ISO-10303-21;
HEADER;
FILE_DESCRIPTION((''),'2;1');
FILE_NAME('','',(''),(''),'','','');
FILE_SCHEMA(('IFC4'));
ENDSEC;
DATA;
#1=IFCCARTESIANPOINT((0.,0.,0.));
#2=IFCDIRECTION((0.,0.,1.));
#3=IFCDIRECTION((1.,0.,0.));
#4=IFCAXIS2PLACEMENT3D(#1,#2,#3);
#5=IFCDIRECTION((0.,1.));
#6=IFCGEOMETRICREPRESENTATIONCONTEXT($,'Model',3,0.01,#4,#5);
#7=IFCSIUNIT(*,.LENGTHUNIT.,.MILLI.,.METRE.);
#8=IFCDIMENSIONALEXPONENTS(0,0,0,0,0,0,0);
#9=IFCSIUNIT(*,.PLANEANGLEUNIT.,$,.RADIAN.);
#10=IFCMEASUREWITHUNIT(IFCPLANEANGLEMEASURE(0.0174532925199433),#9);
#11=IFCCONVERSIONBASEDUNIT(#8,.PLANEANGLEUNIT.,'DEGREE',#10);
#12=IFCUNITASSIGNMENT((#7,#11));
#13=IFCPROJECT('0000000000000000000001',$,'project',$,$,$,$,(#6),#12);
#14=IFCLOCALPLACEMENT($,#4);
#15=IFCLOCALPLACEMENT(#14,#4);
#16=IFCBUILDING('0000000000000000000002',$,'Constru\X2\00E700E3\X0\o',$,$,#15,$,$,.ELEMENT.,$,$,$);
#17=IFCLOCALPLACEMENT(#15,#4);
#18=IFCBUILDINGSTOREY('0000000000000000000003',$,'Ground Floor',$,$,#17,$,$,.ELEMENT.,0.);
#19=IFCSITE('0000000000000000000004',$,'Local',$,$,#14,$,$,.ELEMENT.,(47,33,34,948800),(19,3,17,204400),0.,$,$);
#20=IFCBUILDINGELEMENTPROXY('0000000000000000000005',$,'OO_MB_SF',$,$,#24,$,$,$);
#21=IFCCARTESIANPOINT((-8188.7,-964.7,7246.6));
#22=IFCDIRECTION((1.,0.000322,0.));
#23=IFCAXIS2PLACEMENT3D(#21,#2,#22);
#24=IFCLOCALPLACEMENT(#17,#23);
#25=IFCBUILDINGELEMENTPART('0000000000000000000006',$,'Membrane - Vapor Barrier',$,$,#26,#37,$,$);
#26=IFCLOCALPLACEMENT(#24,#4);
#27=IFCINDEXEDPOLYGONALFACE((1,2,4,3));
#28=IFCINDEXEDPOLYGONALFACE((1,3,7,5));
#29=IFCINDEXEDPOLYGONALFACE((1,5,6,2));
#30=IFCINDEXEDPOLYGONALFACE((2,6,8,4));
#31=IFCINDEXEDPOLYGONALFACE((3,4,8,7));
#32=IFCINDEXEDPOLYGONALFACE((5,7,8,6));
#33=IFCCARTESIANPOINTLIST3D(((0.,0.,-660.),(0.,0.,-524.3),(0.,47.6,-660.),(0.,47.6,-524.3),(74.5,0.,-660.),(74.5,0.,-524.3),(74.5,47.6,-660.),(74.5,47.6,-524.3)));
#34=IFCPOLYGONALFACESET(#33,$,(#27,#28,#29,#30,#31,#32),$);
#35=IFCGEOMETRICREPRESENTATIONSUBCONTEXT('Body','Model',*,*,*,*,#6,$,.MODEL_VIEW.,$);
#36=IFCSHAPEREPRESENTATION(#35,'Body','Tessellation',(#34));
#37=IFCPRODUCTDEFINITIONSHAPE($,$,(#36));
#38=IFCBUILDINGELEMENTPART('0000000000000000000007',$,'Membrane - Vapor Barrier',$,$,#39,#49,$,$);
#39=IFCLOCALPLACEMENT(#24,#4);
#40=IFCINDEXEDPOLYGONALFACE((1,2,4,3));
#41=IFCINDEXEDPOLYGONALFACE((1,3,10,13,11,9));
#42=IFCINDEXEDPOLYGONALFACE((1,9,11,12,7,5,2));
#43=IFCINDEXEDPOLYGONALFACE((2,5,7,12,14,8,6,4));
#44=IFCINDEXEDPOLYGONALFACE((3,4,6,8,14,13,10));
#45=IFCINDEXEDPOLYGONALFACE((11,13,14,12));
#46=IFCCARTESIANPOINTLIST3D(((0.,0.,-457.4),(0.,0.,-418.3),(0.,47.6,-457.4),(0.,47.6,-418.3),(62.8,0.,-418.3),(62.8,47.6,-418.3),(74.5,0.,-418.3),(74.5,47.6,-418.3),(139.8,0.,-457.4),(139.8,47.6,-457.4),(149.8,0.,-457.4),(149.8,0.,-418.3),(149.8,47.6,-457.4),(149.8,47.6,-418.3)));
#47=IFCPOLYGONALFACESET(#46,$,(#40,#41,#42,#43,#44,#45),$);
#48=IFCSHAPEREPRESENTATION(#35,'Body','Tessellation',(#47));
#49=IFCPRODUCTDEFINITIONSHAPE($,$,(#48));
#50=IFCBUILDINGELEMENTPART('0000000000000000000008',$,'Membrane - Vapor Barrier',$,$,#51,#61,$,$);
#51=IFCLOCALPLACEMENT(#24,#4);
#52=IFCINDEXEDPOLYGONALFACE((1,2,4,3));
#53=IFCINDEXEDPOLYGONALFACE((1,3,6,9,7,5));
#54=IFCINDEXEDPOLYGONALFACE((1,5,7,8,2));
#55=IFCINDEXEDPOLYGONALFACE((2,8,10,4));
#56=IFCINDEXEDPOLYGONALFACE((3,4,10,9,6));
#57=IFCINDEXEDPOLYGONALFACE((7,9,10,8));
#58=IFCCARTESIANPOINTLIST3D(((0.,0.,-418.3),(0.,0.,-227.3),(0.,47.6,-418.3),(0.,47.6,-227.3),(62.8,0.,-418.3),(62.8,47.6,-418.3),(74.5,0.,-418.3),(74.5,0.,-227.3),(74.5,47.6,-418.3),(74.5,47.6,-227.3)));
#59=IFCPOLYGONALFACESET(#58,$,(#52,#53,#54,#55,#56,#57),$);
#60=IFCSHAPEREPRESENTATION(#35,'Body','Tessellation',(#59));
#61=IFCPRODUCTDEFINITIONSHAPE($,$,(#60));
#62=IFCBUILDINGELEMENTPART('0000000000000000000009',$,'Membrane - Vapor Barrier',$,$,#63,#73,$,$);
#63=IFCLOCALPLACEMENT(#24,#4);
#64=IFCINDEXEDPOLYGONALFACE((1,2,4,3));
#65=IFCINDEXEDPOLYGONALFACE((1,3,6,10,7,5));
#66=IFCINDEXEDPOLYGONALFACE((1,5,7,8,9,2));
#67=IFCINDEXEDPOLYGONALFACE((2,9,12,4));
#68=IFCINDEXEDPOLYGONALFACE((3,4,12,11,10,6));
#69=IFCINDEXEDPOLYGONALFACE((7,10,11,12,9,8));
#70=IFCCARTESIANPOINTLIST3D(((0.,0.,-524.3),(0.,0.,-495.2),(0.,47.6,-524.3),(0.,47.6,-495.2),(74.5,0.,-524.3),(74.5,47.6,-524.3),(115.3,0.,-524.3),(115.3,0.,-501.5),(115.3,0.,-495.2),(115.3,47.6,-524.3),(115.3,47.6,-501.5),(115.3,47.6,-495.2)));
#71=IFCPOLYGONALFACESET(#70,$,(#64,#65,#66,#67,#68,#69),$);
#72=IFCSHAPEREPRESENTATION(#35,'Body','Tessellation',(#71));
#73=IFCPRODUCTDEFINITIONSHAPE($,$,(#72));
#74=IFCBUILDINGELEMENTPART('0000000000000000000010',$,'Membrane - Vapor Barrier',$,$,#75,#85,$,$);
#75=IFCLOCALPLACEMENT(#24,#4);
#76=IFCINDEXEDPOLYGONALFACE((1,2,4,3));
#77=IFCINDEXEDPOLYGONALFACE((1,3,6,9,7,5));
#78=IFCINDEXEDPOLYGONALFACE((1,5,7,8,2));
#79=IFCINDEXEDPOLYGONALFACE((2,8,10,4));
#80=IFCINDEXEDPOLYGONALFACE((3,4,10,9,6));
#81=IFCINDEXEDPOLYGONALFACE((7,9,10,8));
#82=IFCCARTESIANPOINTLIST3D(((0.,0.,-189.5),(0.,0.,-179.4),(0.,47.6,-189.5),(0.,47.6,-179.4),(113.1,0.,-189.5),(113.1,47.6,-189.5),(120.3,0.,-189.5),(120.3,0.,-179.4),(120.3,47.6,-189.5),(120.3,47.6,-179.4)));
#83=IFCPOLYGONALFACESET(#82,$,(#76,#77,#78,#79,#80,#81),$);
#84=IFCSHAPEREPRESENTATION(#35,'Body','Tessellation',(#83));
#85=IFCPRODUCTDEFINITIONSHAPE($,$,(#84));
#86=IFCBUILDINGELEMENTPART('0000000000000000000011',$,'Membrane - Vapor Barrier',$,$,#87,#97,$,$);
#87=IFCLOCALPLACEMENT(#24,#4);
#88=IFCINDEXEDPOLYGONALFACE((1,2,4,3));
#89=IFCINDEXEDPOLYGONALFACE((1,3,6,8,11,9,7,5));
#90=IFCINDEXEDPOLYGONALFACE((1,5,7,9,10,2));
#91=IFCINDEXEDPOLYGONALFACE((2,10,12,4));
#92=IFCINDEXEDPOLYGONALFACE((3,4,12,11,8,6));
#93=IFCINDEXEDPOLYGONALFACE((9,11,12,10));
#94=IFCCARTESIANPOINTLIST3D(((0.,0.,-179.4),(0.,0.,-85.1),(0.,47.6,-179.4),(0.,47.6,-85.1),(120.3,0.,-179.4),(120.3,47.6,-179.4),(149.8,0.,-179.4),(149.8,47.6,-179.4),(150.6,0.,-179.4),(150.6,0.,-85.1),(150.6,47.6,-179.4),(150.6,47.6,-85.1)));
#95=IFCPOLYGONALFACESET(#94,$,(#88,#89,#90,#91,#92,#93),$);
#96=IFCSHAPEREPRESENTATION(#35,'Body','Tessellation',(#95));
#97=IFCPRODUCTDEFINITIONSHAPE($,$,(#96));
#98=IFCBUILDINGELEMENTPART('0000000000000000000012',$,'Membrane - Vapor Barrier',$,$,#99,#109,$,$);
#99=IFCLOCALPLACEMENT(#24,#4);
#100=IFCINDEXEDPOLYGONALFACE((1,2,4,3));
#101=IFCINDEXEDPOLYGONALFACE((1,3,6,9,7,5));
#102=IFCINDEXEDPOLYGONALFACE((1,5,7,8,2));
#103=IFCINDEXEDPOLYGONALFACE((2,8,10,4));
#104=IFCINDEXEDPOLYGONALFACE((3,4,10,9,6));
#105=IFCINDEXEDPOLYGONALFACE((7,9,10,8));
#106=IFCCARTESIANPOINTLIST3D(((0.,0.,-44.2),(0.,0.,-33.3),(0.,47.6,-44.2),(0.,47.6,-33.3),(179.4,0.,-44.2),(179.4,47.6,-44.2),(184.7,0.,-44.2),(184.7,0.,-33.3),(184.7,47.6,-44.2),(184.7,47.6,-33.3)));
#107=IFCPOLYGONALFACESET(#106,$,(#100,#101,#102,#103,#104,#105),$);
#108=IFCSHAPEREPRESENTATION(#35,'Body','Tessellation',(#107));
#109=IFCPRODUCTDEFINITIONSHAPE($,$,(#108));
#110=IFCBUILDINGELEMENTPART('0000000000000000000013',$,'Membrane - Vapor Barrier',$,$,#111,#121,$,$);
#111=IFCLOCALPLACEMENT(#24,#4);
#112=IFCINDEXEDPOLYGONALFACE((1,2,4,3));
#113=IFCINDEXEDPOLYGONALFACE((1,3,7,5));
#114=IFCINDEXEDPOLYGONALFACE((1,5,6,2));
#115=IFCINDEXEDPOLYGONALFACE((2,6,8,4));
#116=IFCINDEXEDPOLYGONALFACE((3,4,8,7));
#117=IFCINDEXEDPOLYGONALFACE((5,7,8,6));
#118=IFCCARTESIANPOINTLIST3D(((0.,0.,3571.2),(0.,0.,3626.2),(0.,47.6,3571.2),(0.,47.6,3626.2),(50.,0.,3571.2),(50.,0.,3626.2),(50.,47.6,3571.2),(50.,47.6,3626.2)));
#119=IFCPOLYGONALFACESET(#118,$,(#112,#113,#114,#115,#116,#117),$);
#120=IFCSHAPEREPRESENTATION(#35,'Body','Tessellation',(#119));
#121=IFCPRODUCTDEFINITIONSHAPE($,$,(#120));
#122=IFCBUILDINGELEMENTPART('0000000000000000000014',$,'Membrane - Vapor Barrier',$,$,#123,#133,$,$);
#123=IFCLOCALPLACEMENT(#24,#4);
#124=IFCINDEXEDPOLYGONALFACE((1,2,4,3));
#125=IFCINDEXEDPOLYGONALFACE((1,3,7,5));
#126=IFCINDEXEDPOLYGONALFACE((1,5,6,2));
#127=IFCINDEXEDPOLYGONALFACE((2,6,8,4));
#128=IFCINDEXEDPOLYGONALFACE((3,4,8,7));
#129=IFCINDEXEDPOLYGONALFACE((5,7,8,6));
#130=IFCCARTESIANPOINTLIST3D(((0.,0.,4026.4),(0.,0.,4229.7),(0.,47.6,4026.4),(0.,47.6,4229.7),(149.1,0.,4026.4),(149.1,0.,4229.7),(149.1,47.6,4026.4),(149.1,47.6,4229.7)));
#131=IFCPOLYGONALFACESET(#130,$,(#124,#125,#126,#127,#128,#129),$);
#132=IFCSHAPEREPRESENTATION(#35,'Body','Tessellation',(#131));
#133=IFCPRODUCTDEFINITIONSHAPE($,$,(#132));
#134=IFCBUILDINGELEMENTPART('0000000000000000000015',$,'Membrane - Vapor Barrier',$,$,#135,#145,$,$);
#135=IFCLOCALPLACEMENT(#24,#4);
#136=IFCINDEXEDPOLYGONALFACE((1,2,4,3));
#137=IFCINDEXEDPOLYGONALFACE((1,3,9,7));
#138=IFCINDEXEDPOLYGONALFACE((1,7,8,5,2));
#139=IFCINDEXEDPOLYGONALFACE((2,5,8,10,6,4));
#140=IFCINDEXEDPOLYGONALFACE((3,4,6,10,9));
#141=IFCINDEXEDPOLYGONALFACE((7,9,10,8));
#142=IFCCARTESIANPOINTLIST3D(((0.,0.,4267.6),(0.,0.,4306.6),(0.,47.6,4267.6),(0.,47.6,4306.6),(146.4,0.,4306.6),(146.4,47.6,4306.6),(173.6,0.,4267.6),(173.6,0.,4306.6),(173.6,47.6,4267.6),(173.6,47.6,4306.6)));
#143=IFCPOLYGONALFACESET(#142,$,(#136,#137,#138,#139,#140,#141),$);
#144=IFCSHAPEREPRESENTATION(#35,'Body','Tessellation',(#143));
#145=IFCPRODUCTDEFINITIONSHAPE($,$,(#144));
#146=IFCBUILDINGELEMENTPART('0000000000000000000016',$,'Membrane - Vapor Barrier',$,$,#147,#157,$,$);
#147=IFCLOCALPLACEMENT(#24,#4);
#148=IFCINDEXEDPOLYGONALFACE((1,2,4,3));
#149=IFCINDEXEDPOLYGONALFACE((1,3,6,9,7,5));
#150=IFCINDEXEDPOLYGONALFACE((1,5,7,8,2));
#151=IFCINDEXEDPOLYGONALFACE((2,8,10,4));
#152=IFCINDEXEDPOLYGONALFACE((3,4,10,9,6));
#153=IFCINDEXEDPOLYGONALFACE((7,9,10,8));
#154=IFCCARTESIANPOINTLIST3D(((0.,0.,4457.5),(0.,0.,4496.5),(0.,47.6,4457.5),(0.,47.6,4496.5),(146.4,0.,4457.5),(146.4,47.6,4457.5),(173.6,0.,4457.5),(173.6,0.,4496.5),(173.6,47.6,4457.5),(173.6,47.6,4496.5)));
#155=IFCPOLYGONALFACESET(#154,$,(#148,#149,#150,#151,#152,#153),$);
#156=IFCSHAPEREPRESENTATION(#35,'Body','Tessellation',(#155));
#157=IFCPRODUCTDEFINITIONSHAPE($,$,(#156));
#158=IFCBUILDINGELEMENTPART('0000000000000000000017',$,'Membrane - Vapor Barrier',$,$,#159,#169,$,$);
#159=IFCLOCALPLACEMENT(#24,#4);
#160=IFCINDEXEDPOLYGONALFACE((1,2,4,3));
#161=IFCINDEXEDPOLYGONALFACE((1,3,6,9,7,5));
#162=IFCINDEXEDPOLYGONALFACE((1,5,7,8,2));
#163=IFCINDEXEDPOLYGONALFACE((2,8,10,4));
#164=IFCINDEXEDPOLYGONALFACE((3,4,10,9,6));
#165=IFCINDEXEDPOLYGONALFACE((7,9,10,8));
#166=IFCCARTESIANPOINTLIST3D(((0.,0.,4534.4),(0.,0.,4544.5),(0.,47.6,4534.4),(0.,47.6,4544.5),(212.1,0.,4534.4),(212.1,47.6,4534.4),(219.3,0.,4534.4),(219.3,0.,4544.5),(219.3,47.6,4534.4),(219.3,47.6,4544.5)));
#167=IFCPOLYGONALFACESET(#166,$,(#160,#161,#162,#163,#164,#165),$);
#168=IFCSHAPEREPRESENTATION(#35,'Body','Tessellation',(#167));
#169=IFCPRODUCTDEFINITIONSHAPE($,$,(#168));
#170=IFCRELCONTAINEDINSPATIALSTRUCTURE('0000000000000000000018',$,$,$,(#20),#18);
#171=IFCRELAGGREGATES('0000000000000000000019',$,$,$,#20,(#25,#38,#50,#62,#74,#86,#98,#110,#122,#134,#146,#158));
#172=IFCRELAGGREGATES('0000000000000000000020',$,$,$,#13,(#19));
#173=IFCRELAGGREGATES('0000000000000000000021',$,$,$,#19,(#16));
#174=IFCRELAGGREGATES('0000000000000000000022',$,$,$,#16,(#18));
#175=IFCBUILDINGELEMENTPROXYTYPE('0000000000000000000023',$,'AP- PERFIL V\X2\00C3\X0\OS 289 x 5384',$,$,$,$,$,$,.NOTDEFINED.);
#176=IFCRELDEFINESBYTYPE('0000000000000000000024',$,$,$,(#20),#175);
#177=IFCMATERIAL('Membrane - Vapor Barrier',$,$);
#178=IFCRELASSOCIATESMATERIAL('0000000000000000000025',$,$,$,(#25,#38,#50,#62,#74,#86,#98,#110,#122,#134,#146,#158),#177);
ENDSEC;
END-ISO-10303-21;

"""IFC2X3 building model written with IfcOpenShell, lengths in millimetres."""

from ifc_helpers import new_model, entity, si_unit, converted_unit, direction, frame, origin_with_axes, place, context, subcontext, project, spatial, polyline, outline, extrude, material, type_object, element, aggregate, save


model = new_model("IFC2X3")

# Units and contexts
model_context = context("Model", 3, precision=0.01, world=origin_with_axes(), true_north=direction((0.0, 1.0)))
body_context = subcontext(model_context, "Body", "Model", "MODEL_VIEW")
ifc_project = project(units=[si_unit("LENGTHUNIT", "METRE", prefix="MILLI"), converted_unit("PLANEANGLEUNIT", "DEGREE", entity("IfcPlaneAngleMeasure", 0.0174532925199433), si_unit("PLANEANGLEUNIT", "RADIAN"), dimensions=[0, 0, 0, 0, 0, 0, 0])], contexts=[model_context])

# Site, building, storey
site_placement = place(None, origin_with_axes())
site = spatial("IfcSite", under=ifc_project, at=site_placement, Name="Local", CompositionType="ELEMENT", RefLatitude=(47, 33, 34, 948800), RefLongitude=(19, 3, 17, 204400), RefElevation=0.0)
building_placement = place(site_placement, origin_with_axes())
building = spatial("IfcBuilding", under=site, at=building_placement, Name="Construção", CompositionType="ELEMENT")
storey_placement = place(building_placement, origin_with_axes())
storey = spatial("IfcBuildingStorey", under=building, at=storey_placement, Name="Ground Floor", CompositionType="ELEMENT", Elevation=0.0)

# Building element proxy, building element parts
building_element_proxy_type = type_object("IfcBuildingElementProxyType", Name="AP- PERFIL VÃOS 289 x 5384", PredefinedType="NOTDEFINED")
proxy_1_placement = place(storey_placement, frame((-8188.7, -964.7, 7246.6), z_axis=(0.0, 0.0, 1.0), x_axis=(1.0, 0.000322, 0.0)))
proxy_1 = element("IfcBuildingElementProxy", 1, at=proxy_1_placement, inside=storey, type_object=building_element_proxy_type, Name="OO_MB_SF")
ifc_material = material(Name="Membrane - Vapor Barrier")
building_element_part_1_placement = place(proxy_1_placement, origin_with_axes())
building_element_part_1 = element("IfcBuildingElementPart", 2, at=building_element_part_1_placement, material=ifc_material, Name="Membrane - Vapor Barrier", context=body_context, shape_type="SweptSolid", body=[
    extrude(outline(polyline([(0.0, -660.0), (74.5, -660.0), (74.5, -524.3), (0.0, -524.3), (0.0, -660.0)])), frame((0.0, 47.6, 0.0), z_axis=(0.0, -1.0, 0.0), x_axis=(1.0, 0.0, 0.0)), (0.0, 0.0, 1.0), 47.6),
])
building_element_part_2_placement = place(proxy_1_placement, origin_with_axes())
building_element_part_2 = element("IfcBuildingElementPart", 3, at=building_element_part_2_placement, material=ifc_material, Name="Membrane - Vapor Barrier", context=body_context, shape_type="SweptSolid", body=[
    extrude(outline(polyline([(62.8, -418.3), (0.0, -418.3), (0.0, -457.4), (139.8, -457.4), (149.8, -457.4), (149.8, -418.3), (74.5, -418.3), (62.8, -418.3)])), frame((0.0, 47.6, 0.0), z_axis=(0.0, -1.0, 0.0), x_axis=(1.0, 0.0, 0.0)), (0.0, 0.0, 1.0), 47.6),
])
building_element_part_3_placement = place(proxy_1_placement, origin_with_axes())
building_element_part_3 = element("IfcBuildingElementPart", 4, at=building_element_part_3_placement, material=ifc_material, Name="Membrane - Vapor Barrier", context=body_context, shape_type="SweptSolid", body=[
    extrude(outline(polyline([(0.0, -227.3), (0.0, -418.3), (62.8, -418.3), (74.5, -418.3), (74.5, -227.3), (0.0, -227.3)])), frame((0.0, 47.6, 0.0), z_axis=(0.0, -1.0, 0.0), x_axis=(1.0, 0.0, 0.0)), (0.0, 0.0, 1.0), 47.6),
])
building_element_part_4_placement = place(proxy_1_placement, origin_with_axes())
building_element_part_4 = element("IfcBuildingElementPart", 5, at=building_element_part_4_placement, material=ifc_material, Name="Membrane - Vapor Barrier", context=body_context, shape_type="SweptSolid", body=[
    extrude(outline(polyline([(0.0, -524.3), (74.5, -524.3), (115.3, -524.3), (115.3, -501.5), (115.3, -495.2), (0.0, -495.2), (0.0, -524.3)])), frame((0.0, 47.6, 0.0), z_axis=(0.0, -1.0, 0.0), x_axis=(1.0, 0.0, 0.0)), (0.0, 0.0, 1.0), 47.6),
])
building_element_part_5_placement = place(proxy_1_placement, origin_with_axes())
building_element_part_5 = element("IfcBuildingElementPart", 6, at=building_element_part_5_placement, material=ifc_material, Name="Membrane - Vapor Barrier", context=body_context, shape_type="SweptSolid", body=[
    extrude(outline(polyline([(120.3, -179.4), (0.0, -179.4), (0.0, -189.5), (113.1, -189.5), (120.3, -189.5), (120.3, -179.4)])), frame((0.0, 47.6, 0.0), z_axis=(0.0, -1.0, 0.0), x_axis=(1.0, 0.0, 0.0)), (0.0, 0.0, 1.0), 47.6),
])
building_element_part_6_placement = place(proxy_1_placement, origin_with_axes())
building_element_part_6 = element("IfcBuildingElementPart", 7, at=building_element_part_6_placement, material=ifc_material, Name="Membrane - Vapor Barrier", context=body_context, shape_type="SweptSolid", body=[
    extrude(outline(polyline([(0.0, -85.1), (0.0, -179.4), (120.3, -179.4), (149.8, -179.4), (150.6, -179.4), (150.6, -85.1), (0.0, -85.1)])), frame((0.0, 47.6, 0.0), z_axis=(0.0, -1.0, 0.0), x_axis=(1.0, 0.0, 0.0)), (0.0, 0.0, 1.0), 47.6),
])
building_element_part_7_placement = place(proxy_1_placement, origin_with_axes())
building_element_part_7 = element("IfcBuildingElementPart", 8, at=building_element_part_7_placement, material=ifc_material, Name="Membrane - Vapor Barrier", context=body_context, shape_type="SweptSolid", body=[
    extrude(outline(polyline([(184.7, -33.3), (0.0, -33.3), (0.0, -44.2), (179.4, -44.2), (184.7, -44.2), (184.7, -33.3)])), frame((0.0, 47.6, 0.0), z_axis=(0.0, -1.0, 0.0), x_axis=(1.0, 0.0, 0.0)), (0.0, 0.0, 1.0), 47.6),
])
building_element_part_8_placement = place(proxy_1_placement, origin_with_axes())
building_element_part_8 = element("IfcBuildingElementPart", 9, at=building_element_part_8_placement, material=ifc_material, Name="Membrane - Vapor Barrier", context=body_context, shape_type="SweptSolid", body=[
    extrude(outline(polyline([(0.0, 3571.2), (50.0, 3571.2), (50.0, 3626.2), (0.0, 3626.2), (0.0, 3571.2)])), frame((0.0, 47.6, 0.0), z_axis=(0.0, -1.0, 0.0), x_axis=(1.0, 0.0, 0.0)), (0.0, 0.0, 1.0), 47.6),
])
building_element_part_9_placement = place(proxy_1_placement, origin_with_axes())
building_element_part_9 = element("IfcBuildingElementPart", 10, at=building_element_part_9_placement, material=ifc_material, Name="Membrane - Vapor Barrier", context=body_context, shape_type="SweptSolid", body=[
    extrude(outline(polyline([(149.1, 4229.7), (0.0, 4229.7), (0.0, 4026.4), (149.1, 4026.4), (149.1, 4229.7)])), frame((0.0, 47.6, 0.0), z_axis=(0.0, -1.0, 0.0), x_axis=(1.0, 0.0, 0.0)), (0.0, 0.0, 1.0), 47.6),
])
building_element_part_10_placement = place(proxy_1_placement, origin_with_axes())
building_element_part_10 = element("IfcBuildingElementPart", 11, at=building_element_part_10_placement, material=ifc_material, Name="Membrane - Vapor Barrier", context=body_context, shape_type="SweptSolid", body=[
    extrude(outline(polyline([(0.0, 4306.6), (0.0, 4267.6), (173.6, 4267.6), (173.6, 4306.6), (146.4, 4306.6), (0.0, 4306.6)])), frame((0.0, 47.6, 0.0), z_axis=(0.0, -1.0, 0.0), x_axis=(1.0, 0.0, 0.0)), (0.0, 0.0, 1.0), 47.6),
])
building_element_part_11_placement = place(proxy_1_placement, origin_with_axes())
building_element_part_11 = element("IfcBuildingElementPart", 12, at=building_element_part_11_placement, material=ifc_material, Name="Membrane - Vapor Barrier", context=body_context, shape_type="SweptSolid", body=[
    extrude(outline(polyline([(173.6, 4496.5), (0.0, 4496.5), (0.0, 4457.5), (146.4, 4457.5), (173.6, 4457.5), (173.6, 4496.5)])), frame((0.0, 47.6, 0.0), z_axis=(0.0, -1.0, 0.0), x_axis=(1.0, 0.0, 0.0)), (0.0, 0.0, 1.0), 47.6),
])
building_element_part_12_placement = place(proxy_1_placement, origin_with_axes())
building_element_part_12 = element("IfcBuildingElementPart", 13, at=building_element_part_12_placement, material=ifc_material, Name="Membrane - Vapor Barrier", context=body_context, shape_type="SweptSolid", body=[
    extrude(outline(polyline([(0.0, 4534.4), (212.1, 4534.4), (219.3, 4534.4), (219.3, 4544.5), (0.0, 4544.5), (0.0, 4534.4)])), frame((0.0, 47.6, 0.0), z_axis=(0.0, -1.0, 0.0), x_axis=(1.0, 0.0, 0.0)), (0.0, 0.0, 1.0), 47.6),
])
aggregate(proxy_1, [building_element_part_1, building_element_part_2, building_element_part_3, building_element_part_4, building_element_part_5, building_element_part_6, building_element_part_7, building_element_part_8, building_element_part_9, building_element_part_10, building_element_part_11, building_element_part_12])

save(model, "model.ifc")
